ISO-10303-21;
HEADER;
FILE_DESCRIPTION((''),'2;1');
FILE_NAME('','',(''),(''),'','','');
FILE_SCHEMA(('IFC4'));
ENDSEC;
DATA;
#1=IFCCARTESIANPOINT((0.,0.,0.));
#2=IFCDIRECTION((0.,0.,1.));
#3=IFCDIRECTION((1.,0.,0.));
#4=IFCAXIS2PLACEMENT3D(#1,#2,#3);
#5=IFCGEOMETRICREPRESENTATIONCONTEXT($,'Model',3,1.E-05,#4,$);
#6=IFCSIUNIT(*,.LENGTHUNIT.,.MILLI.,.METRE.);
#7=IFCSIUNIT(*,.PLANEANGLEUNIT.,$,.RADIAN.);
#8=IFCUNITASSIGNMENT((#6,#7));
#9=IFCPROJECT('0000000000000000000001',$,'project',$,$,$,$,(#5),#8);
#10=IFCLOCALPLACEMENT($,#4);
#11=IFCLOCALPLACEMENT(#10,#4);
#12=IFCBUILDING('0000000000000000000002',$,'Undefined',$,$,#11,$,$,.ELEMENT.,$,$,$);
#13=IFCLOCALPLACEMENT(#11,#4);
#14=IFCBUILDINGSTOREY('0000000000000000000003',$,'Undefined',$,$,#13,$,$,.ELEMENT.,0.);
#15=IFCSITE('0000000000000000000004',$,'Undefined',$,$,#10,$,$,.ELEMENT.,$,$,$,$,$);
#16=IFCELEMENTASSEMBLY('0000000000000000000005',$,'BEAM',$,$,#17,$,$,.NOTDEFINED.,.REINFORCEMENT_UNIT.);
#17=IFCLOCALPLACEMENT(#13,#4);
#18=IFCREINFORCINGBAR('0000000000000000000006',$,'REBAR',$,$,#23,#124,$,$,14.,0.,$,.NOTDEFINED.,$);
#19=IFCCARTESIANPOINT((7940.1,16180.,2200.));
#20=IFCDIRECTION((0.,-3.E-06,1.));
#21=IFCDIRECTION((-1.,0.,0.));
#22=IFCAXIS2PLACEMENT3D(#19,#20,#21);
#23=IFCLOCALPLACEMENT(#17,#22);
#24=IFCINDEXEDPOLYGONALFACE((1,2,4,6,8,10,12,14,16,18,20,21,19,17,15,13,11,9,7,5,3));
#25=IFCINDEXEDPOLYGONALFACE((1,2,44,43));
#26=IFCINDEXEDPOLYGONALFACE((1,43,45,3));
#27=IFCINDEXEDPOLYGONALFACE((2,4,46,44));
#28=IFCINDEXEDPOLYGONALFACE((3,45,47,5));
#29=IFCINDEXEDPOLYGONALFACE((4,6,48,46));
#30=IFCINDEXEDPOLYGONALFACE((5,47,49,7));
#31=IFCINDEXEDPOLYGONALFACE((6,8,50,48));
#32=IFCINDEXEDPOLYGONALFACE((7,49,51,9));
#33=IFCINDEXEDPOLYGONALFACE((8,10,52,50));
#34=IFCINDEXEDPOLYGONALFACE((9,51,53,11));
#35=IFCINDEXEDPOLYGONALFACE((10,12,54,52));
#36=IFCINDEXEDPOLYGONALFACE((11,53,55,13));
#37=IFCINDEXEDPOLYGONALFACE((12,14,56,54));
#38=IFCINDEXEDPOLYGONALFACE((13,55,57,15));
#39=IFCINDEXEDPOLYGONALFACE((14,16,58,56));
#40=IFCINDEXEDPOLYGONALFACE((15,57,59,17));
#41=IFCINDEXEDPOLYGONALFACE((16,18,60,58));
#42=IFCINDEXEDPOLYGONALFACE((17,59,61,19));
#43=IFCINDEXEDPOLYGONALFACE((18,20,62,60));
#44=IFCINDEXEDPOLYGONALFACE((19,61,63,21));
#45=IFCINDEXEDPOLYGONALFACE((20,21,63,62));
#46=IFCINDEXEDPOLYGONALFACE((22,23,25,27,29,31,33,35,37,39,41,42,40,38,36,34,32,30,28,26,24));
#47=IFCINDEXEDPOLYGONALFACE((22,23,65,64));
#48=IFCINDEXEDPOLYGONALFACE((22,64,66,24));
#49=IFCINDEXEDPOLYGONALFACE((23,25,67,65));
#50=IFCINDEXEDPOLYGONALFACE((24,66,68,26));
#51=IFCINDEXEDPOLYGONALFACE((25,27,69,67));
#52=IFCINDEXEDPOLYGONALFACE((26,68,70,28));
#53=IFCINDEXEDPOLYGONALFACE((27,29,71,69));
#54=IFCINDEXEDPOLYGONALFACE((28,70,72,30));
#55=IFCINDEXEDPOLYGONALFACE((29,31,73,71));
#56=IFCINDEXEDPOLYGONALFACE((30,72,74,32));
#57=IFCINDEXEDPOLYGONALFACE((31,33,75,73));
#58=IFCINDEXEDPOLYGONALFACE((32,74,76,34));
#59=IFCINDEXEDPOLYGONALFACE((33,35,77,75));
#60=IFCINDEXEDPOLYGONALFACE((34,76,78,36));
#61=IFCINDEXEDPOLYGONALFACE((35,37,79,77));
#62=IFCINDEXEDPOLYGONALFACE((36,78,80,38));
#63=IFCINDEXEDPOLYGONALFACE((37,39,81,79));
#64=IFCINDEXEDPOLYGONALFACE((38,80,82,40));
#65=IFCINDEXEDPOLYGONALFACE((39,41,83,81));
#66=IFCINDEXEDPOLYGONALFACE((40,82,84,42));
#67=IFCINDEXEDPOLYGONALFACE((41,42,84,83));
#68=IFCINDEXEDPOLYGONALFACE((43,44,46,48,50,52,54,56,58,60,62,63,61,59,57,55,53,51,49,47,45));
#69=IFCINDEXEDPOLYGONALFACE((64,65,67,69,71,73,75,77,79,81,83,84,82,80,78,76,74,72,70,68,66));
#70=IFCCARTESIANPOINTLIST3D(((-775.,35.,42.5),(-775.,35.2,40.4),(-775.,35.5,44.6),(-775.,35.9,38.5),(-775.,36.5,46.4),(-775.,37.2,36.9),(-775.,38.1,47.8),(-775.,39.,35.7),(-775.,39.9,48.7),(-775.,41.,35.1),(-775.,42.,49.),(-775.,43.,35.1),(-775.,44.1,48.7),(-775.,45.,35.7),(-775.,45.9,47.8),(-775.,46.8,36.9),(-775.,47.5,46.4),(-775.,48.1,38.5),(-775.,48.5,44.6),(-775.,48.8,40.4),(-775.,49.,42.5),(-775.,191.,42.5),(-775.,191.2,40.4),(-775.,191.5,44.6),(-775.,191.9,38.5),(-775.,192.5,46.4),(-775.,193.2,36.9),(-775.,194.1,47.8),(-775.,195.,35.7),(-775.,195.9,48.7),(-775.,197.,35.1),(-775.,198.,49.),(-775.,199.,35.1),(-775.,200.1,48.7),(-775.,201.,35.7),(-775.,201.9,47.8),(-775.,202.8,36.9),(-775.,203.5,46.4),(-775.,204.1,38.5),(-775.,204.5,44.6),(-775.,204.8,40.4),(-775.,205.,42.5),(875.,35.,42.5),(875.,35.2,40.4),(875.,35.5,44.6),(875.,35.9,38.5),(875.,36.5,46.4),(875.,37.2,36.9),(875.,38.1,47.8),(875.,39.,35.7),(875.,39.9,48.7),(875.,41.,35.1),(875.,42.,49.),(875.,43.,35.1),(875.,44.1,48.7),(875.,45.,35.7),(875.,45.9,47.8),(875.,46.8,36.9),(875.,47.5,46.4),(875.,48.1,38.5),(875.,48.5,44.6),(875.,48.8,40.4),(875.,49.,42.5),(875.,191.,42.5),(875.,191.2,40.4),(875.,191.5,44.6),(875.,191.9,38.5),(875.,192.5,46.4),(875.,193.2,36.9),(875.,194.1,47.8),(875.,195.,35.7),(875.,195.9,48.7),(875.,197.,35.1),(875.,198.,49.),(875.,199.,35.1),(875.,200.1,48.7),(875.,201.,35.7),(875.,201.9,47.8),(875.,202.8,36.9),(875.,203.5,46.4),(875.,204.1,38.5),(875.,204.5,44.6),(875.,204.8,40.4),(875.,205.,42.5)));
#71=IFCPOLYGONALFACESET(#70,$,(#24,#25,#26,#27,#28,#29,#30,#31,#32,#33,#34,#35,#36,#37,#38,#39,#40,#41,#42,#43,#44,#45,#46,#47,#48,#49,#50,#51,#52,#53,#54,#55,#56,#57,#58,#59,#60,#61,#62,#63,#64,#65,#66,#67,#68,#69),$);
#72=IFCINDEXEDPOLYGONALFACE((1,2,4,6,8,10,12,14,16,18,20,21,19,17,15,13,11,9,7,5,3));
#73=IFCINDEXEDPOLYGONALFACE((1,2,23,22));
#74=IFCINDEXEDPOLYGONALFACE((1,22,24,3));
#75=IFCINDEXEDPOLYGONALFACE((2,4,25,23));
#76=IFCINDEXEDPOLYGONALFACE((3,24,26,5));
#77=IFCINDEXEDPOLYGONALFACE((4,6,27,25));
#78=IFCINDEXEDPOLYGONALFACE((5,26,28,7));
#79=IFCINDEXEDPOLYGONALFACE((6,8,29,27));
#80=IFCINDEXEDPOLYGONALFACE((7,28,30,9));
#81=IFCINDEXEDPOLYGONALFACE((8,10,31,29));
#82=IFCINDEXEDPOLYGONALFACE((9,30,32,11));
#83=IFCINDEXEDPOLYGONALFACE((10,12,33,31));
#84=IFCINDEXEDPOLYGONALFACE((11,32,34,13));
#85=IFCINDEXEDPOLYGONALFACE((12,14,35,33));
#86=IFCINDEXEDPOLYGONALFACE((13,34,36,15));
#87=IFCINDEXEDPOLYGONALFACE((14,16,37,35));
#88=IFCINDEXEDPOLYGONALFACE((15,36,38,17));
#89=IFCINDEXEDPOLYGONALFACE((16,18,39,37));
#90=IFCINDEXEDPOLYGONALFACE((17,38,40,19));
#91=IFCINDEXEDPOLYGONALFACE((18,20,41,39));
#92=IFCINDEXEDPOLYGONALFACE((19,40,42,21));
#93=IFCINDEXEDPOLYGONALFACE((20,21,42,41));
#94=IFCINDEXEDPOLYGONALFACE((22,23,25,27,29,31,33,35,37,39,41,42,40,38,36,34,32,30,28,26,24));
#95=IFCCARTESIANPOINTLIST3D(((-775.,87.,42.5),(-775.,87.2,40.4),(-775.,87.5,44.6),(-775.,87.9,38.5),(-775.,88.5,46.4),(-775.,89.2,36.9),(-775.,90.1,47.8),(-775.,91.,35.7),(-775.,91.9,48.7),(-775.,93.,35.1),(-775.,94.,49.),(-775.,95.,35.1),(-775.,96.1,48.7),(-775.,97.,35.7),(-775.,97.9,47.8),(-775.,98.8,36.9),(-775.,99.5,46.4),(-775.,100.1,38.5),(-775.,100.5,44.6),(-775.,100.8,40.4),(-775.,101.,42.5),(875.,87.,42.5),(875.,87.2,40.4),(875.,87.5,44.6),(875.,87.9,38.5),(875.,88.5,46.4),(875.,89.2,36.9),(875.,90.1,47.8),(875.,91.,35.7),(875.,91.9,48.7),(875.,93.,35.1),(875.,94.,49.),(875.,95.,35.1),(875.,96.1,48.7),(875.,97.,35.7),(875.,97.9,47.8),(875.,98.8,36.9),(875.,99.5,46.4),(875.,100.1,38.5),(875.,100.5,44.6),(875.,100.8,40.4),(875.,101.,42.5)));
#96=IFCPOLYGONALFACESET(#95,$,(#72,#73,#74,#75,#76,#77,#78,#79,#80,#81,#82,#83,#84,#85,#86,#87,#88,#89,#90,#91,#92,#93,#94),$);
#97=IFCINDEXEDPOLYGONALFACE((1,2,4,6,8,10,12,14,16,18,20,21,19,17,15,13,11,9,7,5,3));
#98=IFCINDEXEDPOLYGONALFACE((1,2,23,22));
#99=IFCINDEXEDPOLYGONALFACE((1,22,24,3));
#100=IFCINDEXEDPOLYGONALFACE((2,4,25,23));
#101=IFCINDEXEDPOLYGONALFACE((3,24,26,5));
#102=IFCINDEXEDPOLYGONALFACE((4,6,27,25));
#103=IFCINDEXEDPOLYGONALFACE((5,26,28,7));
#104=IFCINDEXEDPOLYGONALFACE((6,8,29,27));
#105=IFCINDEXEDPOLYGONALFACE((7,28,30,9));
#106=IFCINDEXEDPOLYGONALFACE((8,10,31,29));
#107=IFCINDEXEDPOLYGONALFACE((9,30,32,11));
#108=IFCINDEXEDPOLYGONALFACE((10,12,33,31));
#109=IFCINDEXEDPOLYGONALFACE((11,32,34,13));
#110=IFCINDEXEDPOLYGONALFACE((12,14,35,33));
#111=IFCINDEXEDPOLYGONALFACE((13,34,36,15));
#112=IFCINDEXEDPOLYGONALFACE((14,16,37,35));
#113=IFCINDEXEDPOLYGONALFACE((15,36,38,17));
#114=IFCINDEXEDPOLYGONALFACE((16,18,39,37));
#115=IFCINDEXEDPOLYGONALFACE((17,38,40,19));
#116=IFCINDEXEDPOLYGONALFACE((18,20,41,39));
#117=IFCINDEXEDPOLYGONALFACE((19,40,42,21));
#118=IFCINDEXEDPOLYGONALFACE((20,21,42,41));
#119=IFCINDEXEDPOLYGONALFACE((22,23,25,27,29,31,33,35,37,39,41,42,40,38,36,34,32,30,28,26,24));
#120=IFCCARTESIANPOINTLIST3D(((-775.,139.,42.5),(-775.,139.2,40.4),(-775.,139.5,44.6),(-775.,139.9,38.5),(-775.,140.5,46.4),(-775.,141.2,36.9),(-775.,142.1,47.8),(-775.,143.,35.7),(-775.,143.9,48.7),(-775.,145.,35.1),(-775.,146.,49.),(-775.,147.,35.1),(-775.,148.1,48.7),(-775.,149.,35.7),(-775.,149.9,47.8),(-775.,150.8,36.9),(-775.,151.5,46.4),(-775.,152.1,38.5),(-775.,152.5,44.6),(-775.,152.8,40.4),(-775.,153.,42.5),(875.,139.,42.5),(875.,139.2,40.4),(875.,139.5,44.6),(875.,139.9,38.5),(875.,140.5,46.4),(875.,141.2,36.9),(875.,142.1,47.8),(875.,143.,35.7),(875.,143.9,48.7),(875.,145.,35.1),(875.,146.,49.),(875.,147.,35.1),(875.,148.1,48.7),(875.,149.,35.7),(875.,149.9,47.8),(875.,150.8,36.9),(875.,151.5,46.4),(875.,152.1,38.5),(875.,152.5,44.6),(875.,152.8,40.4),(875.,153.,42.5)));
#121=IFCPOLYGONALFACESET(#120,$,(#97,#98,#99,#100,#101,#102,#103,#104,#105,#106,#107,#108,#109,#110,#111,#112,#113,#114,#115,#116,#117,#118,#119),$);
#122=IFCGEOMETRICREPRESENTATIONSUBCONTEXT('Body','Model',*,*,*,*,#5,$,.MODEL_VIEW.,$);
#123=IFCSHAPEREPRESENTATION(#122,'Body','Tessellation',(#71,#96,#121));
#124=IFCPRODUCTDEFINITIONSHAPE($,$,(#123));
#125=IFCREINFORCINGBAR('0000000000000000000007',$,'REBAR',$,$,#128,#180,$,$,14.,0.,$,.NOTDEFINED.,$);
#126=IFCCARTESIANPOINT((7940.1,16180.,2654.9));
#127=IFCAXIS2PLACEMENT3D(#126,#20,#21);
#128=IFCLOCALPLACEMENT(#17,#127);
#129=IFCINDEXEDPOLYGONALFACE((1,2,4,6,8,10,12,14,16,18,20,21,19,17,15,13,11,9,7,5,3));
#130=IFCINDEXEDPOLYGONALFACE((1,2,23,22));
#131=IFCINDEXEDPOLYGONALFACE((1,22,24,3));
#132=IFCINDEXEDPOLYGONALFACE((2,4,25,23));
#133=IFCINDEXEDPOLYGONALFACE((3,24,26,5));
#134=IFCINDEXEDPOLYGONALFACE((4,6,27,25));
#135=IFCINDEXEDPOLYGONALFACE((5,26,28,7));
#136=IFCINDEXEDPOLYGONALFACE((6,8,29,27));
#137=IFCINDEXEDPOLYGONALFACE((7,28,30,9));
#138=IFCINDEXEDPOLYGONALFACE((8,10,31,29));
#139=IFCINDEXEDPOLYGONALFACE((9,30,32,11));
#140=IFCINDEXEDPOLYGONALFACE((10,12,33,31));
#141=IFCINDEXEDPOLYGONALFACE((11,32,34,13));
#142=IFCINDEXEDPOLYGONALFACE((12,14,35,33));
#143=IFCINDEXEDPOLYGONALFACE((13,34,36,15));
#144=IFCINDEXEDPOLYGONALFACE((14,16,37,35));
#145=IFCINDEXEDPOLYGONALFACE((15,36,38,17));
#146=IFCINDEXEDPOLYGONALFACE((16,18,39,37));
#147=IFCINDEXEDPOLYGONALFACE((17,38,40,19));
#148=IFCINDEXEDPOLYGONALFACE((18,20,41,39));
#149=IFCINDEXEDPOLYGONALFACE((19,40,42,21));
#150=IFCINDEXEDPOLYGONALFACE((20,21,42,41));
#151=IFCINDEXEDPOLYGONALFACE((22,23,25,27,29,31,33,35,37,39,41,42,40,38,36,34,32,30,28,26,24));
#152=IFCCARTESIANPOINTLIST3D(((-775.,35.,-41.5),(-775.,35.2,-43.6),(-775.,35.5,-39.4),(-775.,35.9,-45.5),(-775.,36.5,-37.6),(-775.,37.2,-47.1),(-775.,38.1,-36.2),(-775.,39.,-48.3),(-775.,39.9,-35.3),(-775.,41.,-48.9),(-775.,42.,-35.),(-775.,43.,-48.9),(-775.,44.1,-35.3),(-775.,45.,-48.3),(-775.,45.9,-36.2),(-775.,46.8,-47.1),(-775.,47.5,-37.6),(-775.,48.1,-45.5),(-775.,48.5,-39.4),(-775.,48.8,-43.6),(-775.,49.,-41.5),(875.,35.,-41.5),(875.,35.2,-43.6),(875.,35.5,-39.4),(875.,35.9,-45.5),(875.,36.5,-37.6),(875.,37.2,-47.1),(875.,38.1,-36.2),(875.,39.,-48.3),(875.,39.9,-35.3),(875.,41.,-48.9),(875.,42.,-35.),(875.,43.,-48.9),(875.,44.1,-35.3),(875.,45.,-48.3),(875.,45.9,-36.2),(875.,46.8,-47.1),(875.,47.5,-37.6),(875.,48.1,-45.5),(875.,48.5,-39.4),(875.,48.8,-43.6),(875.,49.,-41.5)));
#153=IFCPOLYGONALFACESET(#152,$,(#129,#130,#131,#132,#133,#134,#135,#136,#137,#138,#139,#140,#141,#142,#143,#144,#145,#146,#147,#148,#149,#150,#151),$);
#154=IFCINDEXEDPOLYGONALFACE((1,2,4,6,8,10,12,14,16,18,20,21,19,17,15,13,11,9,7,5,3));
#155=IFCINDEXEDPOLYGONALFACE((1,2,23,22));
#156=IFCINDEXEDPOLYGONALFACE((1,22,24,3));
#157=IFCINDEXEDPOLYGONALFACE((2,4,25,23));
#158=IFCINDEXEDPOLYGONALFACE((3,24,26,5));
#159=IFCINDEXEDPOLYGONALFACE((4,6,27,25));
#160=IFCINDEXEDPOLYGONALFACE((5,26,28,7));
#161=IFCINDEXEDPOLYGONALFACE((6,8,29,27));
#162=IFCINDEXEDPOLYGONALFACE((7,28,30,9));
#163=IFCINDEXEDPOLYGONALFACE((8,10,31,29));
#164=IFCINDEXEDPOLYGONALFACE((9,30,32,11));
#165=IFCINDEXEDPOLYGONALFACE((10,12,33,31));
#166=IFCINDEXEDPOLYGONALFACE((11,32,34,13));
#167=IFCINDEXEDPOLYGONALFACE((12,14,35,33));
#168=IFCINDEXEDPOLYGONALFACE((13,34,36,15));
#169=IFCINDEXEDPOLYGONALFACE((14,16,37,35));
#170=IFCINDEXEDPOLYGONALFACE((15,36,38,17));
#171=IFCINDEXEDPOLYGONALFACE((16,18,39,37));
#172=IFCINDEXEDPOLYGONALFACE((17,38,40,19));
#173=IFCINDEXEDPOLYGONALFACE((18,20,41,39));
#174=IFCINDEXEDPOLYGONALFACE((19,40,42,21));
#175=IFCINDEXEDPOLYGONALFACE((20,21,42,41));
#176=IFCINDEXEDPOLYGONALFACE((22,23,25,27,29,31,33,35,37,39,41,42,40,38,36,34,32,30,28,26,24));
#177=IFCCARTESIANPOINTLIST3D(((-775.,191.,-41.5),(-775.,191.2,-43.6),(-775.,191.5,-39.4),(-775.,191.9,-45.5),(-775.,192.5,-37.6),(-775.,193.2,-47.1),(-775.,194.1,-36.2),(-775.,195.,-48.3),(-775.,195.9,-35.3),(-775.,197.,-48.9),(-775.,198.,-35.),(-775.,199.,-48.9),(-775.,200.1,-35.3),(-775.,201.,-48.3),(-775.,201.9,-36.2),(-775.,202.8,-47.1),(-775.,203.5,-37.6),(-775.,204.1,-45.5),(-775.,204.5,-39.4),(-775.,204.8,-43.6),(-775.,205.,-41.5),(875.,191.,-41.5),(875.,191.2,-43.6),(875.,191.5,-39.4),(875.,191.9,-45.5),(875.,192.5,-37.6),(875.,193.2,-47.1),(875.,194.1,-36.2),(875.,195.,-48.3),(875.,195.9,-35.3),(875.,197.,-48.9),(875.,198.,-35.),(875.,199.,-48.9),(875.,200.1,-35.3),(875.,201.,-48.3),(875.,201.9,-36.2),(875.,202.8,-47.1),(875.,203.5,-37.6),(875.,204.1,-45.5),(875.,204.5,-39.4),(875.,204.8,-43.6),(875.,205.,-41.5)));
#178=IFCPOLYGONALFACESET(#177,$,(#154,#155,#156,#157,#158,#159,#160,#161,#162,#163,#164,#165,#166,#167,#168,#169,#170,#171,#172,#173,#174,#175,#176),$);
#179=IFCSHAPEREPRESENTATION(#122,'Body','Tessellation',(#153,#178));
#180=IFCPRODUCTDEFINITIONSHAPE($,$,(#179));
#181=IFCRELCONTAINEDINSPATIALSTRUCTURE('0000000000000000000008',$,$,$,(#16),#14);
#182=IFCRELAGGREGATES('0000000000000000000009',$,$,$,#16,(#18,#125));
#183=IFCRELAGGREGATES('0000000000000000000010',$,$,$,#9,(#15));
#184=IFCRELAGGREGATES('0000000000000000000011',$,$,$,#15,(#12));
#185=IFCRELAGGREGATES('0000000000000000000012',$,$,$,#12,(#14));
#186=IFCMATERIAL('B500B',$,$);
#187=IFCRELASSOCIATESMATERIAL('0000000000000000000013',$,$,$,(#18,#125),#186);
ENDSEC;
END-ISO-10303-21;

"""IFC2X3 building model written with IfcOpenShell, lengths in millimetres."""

from ifc_helpers import new_model, entity, si_unit, frame, origin_with_axes, place, context, subcontext, project, spatial, source, transform, mapped, material, element, aggregate, save


model = new_model("IFC2X3")

# Units and contexts
model_context = context("Model", 3, precision=1e-05, world=origin_with_axes())
body_context = subcontext(model_context, "Body", "Model", "MODEL_VIEW")
ifc_project = project(units=[si_unit("LENGTHUNIT", "METRE", prefix="MILLI"), si_unit("PLANEANGLEUNIT", "RADIAN")], contexts=[model_context])

# Site, building, storey
site_placement = place(None, origin_with_axes())
site = spatial("IfcSite", under=ifc_project, at=site_placement, Name="Undefined", CompositionType="ELEMENT")
building_placement = place(site_placement, origin_with_axes())
building = spatial("IfcBuilding", under=site, at=building_placement, Name="Undefined", CompositionType="ELEMENT")
storey_placement = place(building_placement, origin_with_axes())
storey = spatial("IfcBuildingStorey", under=building, at=storey_placement, Name="Undefined", CompositionType="ELEMENT", Elevation=0.0)

# Element assembly
assembly_1_placement = place(storey_placement, origin_with_axes())
assembly_1 = element("IfcElementAssembly", 1, at=assembly_1_placement, inside=storey, Name="BEAM", AssemblyPlace="NOTDEFINED", PredefinedType="REINFORCEMENT_UNIT")

# Shared definitions
ifc_material_1 = material(Name="B500B")

# Reinforcing bars
shared_shape_1 = source(origin_with_axes(), body_context, "Body", "AdvancedSweptSolid", [
    entity("IfcSweptDiskSolid", entity("IfcTrimmedCurve", entity("IfcLine", entity("IfcCartesianPoint", [0.0, 0.0, 0.0]), entity("IfcVector", entity("IfcDirection", [1.0, 0.0, 0.0]), 1.0)), [entity("IfcParameterValue", 0.0)], [entity("IfcParameterValue", 1649.999613)], True, "PARAMETER"), 7.0, None, 0.0, 1650.0),
])
shared_shape_2 = source(origin_with_axes(), body_context, "Body", "AdvancedSweptSolid", [
    entity("IfcSweptDiskSolid", entity("IfcTrimmedCurve", entity("IfcLine", entity("IfcCartesianPoint", [0.0, 0.0, 0.0]), entity("IfcVector", entity("IfcDirection", [1.0, 0.0, 0.0]), 1.0)), [entity("IfcParameterValue", 0.0)], [entity("IfcParameterValue", 1649.999613)], True, "PARAMETER"), 7.0, None, 0.0, 1650.0),
])
shared_shape_3 = source(origin_with_axes(), body_context, "Body", "AdvancedSweptSolid", [
    entity("IfcSweptDiskSolid", entity("IfcTrimmedCurve", entity("IfcLine", entity("IfcCartesianPoint", [0.0, 0.0, 0.0]), entity("IfcVector", entity("IfcDirection", [1.0, 0.0, 0.0]), 1.0)), [entity("IfcParameterValue", 0.0)], [entity("IfcParameterValue", 1649.999613)], True, "PARAMETER"), 7.0, None, 0.0, 1650.0),
])
shared_shape_4 = source(origin_with_axes(), body_context, "Body", "AdvancedSweptSolid", [
    entity("IfcSweptDiskSolid", entity("IfcTrimmedCurve", entity("IfcLine", entity("IfcCartesianPoint", [0.0, 0.0, 0.0]), entity("IfcVector", entity("IfcDirection", [1.0, 0.0, 0.0]), 1.0)), [entity("IfcParameterValue", 0.0)], [entity("IfcParameterValue", 1649.999613)], True, "PARAMETER"), 7.0, None, 0.0, 1650.0),
])
reinforcing_bar_1_placement = place(assembly_1_placement, frame((7940.1, 16180.0, 2200.0), z_axis=(0.0, -0.000003, 1.0), x_axis=(-1.0, 0.0, 0.0)))
reinforcing_bar_1 = element("IfcReinforcingBar", 2, at=reinforcing_bar_1_placement, material=ifc_material_1, Name="REBAR", BarRole="NOTDEFINED", CrossSectionArea=0.0, NominalDiameter=14.0, context=body_context, shape_type="MappedRepresentation", body=[
    mapped(shared_shape_1, transform((-775.0, 42.0, 42.0))),
    mapped(shared_shape_2, transform((-775.0, 94.0, 42.0))),
    mapped(shared_shape_3, transform((-775.0, 146.0, 42.0))),
    mapped(shared_shape_4, transform((-775.0, 198.0, 42.0))),
])
shared_shape_5 = source(origin_with_axes(), body_context, "Body", "AdvancedSweptSolid", [
    entity("IfcSweptDiskSolid", entity("IfcTrimmedCurve", entity("IfcLine", entity("IfcCartesianPoint", [0.0, 0.0, 0.0]), entity("IfcVector", entity("IfcDirection", [1.0, 0.0, 0.0]), 1.0)), [entity("IfcParameterValue", 0.0)], [entity("IfcParameterValue", 1649.999613)], True, "PARAMETER"), 7.0, None, 0.0, 1650.0),
])
shared_shape_6 = source(origin_with_axes(), body_context, "Body", "AdvancedSweptSolid", [
    entity("IfcSweptDiskSolid", entity("IfcTrimmedCurve", entity("IfcLine", entity("IfcCartesianPoint", [0.0, 0.0, 0.0]), entity("IfcVector", entity("IfcDirection", [1.0, 0.0, 0.0]), 1.0)), [entity("IfcParameterValue", 0.0)], [entity("IfcParameterValue", 1649.999613)], True, "PARAMETER"), 7.0, None, 0.0, 1650.0),
])
reinforcing_bar_2_placement = place(assembly_1_placement, frame((7940.1, 16180.0, 2654.9), z_axis=(0.0, -0.000003, 1.0), x_axis=(-1.0, 0.0, 0.0)))
reinforcing_bar_2 = element("IfcReinforcingBar", 3, at=reinforcing_bar_2_placement, material=ifc_material_1, Name="REBAR", BarRole="NOTDEFINED", CrossSectionArea=0.0, NominalDiameter=14.0, context=body_context, shape_type="MappedRepresentation", body=[
    mapped(shared_shape_5, transform((-775.0, 42.0, -42.0))),
    mapped(shared_shape_6, transform((-775.0, 198.0, -42.0))),
])
aggregate(assembly_1, [reinforcing_bar_1, reinforcing_bar_2])

save(model, "model.ifc")
